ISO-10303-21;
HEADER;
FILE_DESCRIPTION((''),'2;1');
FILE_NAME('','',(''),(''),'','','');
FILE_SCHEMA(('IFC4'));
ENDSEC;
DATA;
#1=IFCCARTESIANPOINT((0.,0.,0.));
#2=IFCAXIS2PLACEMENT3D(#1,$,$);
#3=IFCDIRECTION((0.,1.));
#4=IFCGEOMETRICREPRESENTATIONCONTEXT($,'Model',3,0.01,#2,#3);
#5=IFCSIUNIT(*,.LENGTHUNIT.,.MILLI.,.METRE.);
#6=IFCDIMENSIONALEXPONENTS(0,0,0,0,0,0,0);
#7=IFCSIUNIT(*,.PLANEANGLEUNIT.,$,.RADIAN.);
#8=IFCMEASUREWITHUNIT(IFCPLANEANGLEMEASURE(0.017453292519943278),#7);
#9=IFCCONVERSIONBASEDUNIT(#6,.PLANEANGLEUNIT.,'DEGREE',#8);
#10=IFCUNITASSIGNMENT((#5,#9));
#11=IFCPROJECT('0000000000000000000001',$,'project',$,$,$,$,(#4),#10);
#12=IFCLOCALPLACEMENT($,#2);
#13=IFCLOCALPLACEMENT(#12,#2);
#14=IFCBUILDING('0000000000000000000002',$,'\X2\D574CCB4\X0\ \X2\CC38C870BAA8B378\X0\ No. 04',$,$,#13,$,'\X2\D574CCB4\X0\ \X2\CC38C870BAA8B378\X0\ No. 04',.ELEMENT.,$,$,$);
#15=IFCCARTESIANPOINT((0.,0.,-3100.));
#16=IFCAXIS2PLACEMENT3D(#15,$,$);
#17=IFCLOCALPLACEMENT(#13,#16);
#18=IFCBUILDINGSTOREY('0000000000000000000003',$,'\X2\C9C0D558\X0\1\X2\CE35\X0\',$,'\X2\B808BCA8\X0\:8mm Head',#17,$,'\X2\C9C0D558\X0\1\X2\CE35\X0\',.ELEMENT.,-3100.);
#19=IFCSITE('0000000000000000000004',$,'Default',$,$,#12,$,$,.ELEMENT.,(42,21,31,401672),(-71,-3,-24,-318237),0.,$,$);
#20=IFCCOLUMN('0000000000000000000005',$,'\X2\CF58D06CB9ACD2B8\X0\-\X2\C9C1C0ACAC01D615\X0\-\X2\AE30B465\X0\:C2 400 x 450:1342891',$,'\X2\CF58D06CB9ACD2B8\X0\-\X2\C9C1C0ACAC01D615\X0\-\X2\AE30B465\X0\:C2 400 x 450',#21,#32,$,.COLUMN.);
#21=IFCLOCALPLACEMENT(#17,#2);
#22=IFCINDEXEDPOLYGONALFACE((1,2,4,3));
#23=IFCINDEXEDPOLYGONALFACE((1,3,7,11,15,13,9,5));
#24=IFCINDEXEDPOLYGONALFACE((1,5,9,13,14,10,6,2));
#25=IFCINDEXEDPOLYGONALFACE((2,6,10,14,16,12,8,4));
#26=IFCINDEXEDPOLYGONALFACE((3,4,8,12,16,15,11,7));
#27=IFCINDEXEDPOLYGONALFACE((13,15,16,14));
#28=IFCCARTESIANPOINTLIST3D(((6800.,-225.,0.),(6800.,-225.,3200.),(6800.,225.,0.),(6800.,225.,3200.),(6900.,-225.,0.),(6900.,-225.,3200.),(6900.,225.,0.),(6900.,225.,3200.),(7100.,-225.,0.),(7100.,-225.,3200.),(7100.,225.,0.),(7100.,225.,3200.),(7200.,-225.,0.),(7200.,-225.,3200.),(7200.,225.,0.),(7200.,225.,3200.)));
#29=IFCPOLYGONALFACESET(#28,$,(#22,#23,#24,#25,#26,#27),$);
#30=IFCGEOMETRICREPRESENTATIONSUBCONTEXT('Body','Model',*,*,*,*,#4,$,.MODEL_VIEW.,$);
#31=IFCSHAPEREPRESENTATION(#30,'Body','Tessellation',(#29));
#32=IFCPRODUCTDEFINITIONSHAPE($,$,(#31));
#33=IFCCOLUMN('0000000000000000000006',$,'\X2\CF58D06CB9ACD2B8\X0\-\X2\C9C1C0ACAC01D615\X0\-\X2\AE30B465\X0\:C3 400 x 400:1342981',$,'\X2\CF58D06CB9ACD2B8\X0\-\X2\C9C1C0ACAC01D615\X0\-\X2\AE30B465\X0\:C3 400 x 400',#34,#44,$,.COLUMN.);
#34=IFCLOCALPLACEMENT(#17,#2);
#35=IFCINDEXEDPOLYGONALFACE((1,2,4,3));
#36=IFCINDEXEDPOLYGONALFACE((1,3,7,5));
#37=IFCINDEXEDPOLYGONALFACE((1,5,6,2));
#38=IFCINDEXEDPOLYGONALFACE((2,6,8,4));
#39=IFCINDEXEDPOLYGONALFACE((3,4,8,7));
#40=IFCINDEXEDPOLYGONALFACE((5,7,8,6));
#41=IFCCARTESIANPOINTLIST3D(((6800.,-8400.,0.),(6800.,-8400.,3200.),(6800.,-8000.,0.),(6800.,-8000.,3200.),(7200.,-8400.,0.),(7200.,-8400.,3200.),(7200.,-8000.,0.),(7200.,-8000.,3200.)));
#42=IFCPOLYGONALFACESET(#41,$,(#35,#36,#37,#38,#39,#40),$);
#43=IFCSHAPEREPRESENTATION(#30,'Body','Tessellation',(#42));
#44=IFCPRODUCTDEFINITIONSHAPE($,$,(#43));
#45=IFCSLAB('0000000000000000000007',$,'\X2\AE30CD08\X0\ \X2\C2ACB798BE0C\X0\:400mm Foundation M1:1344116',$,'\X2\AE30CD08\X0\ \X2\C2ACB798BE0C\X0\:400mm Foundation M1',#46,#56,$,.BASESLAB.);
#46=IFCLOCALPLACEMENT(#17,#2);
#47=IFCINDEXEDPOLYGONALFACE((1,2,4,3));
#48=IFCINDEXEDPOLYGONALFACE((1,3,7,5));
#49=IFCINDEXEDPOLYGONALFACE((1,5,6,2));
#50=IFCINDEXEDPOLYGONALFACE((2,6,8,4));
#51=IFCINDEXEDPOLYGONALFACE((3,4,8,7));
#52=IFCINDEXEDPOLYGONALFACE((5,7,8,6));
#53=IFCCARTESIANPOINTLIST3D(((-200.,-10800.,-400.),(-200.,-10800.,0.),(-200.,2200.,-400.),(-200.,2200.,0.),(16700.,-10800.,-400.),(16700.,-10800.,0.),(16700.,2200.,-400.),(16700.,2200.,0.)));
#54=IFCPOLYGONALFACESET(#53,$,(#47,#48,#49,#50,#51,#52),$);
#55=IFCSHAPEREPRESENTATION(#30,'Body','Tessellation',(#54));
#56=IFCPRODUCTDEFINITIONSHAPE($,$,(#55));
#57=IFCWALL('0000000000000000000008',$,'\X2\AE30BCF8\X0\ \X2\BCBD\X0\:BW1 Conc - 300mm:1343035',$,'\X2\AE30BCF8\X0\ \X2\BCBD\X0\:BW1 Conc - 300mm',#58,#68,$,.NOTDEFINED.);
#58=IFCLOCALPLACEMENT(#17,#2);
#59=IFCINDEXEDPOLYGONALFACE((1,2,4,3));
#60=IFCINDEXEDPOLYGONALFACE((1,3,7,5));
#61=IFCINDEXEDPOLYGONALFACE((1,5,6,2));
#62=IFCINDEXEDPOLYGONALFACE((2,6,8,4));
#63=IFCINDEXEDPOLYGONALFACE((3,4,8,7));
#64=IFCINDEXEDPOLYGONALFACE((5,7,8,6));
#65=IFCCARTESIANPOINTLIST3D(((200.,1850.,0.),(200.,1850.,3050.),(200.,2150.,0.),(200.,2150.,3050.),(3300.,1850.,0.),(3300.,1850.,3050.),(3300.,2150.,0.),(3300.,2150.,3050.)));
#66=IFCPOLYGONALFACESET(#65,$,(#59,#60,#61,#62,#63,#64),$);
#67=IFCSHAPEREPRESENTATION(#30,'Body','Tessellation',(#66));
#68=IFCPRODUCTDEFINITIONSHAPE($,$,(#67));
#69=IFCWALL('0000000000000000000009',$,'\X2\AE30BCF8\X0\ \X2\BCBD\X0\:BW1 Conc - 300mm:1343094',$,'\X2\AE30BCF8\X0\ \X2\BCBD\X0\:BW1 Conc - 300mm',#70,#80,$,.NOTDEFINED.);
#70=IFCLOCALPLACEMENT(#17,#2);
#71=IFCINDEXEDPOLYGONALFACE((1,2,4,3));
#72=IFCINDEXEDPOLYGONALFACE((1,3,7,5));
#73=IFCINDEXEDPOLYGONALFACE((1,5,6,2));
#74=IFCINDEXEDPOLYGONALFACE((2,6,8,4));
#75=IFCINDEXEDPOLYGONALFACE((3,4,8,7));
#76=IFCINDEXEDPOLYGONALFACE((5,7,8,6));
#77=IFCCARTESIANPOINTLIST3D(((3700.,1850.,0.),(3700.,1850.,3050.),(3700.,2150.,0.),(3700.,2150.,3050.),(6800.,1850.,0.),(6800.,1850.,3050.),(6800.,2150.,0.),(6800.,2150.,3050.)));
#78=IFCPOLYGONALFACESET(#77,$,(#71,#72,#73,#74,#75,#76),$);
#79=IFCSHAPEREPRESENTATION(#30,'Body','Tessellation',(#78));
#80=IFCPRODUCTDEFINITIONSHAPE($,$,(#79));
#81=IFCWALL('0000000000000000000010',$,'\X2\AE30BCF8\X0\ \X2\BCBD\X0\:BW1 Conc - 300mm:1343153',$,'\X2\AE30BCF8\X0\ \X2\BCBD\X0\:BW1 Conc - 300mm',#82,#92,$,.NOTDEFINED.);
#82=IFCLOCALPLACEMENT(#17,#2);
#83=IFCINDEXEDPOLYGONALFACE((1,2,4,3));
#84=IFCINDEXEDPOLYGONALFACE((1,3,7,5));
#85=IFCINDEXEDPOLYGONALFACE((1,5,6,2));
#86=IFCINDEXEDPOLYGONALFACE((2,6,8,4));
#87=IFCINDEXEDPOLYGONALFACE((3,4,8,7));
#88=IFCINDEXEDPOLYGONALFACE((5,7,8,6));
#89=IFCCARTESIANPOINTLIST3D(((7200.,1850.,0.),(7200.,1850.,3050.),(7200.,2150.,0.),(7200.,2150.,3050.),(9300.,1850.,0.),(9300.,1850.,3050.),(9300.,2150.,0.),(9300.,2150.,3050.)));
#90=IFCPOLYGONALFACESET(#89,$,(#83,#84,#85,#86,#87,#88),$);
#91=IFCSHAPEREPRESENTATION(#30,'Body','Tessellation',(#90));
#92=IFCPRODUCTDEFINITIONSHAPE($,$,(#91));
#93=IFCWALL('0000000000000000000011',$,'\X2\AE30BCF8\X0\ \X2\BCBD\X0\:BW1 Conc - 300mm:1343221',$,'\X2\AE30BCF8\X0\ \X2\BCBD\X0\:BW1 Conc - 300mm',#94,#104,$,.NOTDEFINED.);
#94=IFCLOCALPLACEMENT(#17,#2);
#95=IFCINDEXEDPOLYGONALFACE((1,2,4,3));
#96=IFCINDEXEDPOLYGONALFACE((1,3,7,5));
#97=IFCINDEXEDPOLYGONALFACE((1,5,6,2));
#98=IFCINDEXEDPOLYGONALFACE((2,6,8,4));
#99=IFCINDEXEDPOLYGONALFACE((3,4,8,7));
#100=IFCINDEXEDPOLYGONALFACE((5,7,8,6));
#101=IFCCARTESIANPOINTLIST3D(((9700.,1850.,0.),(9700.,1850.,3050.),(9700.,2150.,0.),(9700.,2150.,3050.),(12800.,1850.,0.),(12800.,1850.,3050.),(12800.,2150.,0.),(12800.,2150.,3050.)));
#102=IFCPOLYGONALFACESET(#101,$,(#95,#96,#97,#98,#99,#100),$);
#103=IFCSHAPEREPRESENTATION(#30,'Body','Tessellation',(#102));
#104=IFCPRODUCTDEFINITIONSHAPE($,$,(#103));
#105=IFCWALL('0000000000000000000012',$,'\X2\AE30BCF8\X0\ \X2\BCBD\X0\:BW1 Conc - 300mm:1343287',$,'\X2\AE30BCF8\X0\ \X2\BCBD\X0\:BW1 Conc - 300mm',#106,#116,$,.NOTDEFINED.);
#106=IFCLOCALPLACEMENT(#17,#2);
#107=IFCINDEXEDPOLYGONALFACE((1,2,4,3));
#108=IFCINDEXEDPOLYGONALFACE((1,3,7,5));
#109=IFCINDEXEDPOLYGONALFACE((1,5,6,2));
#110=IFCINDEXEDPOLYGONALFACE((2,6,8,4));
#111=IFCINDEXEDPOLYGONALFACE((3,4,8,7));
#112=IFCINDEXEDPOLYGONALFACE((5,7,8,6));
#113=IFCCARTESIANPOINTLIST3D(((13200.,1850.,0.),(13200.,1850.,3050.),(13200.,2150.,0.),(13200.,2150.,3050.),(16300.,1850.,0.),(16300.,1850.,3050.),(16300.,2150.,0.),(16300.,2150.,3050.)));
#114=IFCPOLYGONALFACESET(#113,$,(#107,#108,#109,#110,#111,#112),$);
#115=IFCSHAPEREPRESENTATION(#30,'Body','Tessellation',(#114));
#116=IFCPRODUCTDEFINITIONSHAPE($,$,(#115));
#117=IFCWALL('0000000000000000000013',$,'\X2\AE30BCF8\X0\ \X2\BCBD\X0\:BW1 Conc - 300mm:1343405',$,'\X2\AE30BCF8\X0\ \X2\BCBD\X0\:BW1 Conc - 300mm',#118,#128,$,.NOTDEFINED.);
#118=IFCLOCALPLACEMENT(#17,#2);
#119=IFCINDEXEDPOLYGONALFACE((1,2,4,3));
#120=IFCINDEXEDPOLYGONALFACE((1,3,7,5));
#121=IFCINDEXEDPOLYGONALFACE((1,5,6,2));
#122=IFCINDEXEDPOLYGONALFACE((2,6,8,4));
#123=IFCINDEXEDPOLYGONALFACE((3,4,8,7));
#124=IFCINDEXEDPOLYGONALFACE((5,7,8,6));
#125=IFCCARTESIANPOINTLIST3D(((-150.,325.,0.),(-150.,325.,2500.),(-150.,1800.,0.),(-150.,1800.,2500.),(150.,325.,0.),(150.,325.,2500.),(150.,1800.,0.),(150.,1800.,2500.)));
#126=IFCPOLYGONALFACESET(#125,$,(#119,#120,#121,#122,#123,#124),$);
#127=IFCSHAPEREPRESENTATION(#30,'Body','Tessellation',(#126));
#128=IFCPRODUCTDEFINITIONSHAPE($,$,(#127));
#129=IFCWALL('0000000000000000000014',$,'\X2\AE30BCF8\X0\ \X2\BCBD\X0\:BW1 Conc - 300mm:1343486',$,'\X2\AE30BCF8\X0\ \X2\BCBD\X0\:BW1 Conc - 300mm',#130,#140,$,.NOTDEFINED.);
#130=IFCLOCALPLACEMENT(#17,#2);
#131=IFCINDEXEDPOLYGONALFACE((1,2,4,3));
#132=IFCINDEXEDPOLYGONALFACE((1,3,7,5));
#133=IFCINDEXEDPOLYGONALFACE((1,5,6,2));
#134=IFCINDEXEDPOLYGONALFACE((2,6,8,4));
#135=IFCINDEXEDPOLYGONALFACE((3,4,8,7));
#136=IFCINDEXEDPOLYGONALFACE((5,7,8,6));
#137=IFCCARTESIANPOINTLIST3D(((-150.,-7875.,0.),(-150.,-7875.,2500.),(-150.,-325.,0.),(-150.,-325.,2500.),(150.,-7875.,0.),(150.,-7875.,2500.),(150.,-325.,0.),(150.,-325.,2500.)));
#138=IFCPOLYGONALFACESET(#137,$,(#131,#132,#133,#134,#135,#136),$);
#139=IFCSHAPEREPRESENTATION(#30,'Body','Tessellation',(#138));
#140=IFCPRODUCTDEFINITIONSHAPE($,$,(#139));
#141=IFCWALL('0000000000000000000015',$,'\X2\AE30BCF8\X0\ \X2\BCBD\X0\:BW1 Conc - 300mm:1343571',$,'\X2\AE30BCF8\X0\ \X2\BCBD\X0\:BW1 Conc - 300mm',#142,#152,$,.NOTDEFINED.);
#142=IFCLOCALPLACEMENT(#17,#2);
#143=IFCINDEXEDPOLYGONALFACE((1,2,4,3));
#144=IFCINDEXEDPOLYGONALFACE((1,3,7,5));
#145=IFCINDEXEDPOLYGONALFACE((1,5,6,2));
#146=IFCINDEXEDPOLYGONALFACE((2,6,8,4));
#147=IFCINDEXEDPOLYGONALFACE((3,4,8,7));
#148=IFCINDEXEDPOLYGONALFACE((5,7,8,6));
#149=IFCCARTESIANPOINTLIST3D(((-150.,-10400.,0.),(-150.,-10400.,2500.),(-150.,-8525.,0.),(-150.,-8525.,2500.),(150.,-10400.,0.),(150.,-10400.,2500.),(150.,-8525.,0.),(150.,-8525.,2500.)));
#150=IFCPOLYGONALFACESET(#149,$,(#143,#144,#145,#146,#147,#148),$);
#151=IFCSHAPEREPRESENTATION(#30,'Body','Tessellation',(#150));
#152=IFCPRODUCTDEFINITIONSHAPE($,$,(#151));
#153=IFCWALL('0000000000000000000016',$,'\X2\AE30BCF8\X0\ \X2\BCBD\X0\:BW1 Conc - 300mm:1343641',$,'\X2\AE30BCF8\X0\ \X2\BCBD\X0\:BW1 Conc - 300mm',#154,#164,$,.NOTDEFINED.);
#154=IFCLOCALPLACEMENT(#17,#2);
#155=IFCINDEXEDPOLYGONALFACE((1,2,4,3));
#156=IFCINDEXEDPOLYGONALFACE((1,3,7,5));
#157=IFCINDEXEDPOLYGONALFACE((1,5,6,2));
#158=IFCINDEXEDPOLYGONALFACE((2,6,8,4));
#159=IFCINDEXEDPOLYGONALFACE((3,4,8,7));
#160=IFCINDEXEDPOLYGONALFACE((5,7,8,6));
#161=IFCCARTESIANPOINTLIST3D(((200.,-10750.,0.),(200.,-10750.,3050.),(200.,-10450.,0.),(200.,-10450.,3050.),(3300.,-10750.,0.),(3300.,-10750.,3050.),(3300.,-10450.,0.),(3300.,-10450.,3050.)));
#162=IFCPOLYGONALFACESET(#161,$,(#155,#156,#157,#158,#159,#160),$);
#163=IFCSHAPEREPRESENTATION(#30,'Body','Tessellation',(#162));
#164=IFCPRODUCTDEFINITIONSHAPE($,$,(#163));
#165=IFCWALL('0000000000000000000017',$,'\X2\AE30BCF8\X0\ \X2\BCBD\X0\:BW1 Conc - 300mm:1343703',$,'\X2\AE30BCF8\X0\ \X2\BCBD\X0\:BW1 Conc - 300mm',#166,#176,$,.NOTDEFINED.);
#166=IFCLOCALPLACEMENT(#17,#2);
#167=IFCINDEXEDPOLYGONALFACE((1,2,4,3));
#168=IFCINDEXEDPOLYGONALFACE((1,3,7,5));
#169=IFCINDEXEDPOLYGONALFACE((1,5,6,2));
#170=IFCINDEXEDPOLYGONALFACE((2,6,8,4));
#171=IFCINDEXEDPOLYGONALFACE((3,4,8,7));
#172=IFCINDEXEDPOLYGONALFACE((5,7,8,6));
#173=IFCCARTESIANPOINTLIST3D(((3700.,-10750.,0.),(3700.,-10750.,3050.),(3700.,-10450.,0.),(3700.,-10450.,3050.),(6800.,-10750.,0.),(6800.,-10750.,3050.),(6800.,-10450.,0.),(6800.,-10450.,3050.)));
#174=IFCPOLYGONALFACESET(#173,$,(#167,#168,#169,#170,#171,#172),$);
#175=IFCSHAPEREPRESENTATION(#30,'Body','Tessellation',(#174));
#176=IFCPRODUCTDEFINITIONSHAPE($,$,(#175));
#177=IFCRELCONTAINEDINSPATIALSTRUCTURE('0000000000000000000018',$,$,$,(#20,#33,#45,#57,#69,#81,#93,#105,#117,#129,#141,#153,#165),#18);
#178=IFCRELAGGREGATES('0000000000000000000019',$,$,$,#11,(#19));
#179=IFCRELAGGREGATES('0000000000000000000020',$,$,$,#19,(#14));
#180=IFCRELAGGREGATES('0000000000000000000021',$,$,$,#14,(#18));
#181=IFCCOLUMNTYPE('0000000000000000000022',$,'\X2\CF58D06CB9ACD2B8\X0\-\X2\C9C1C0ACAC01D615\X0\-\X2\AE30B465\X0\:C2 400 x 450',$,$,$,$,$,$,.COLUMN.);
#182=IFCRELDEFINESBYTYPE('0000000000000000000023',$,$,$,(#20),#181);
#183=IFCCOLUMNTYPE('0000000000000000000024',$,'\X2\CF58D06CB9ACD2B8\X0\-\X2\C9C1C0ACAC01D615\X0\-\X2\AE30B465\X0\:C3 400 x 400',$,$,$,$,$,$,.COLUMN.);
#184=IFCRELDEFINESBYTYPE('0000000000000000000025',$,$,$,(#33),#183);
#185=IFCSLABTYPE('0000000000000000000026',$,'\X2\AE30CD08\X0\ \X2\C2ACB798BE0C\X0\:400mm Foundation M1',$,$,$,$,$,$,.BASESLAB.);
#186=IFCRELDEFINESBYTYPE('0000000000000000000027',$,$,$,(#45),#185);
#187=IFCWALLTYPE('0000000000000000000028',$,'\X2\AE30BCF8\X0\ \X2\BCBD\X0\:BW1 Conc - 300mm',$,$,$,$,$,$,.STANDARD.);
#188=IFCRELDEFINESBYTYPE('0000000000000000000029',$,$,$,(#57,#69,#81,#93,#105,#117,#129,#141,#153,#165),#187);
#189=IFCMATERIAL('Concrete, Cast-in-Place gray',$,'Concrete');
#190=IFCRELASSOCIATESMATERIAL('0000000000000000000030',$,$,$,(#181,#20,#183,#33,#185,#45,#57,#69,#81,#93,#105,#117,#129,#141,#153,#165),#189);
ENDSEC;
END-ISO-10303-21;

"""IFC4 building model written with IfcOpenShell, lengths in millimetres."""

from ifc_helpers import new_model, entity, si_unit, converted_unit, direction, frame, origin, place, context, subcontext, project, spatial, indexed_curve, outline, extrude, source, transform, mapped, material, type_object, type_shapes, element, save


model = new_model("IFC4")

# Units and contexts
model_context = context("Model", 3, precision=0.01, world=origin(), true_north=direction((0.0, 1.0)))
body_context = subcontext(model_context, "Body", "Model", "MODEL_VIEW")
ifc_project = project(units=[si_unit("LENGTHUNIT", "METRE", prefix="MILLI"), converted_unit("PLANEANGLEUNIT", "DEGREE", entity("IfcPlaneAngleMeasure", 0.017453292519943278), si_unit("PLANEANGLEUNIT", "RADIAN"), dimensions=[0, 0, 0, 0, 0, 0, 0])], contexts=[model_context])

# Site, building, storey
site_placement = place(None, origin())
site = spatial("IfcSite", under=ifc_project, at=site_placement, Name="Default", CompositionType="ELEMENT", RefLatitude=(42, 21, 31, 401672), RefLongitude=(-71, -3, -24, -318237), RefElevation=0.0)
building_placement = place(site_placement, origin())
building = spatial("IfcBuilding", under=site, at=building_placement, Name="해체 참조모델 No. 04", LongName="해체 참조모델 No. 04", CompositionType="ELEMENT")
storey_placement = place(building_placement, frame((0.0, 0.0, -3100.0)))
storey = spatial("IfcBuildingStorey", under=building, at=storey_placement, Name="지하1층", ObjectType="레벨:8mm Head", LongName="지하1층", CompositionType="ELEMENT", Elevation=-3100.0)

# Columns
ifc_material_1 = material(Name="Concrete, Cast-in-Place gray", Category="Concrete")
column_type_1 = type_object("IfcColumnType", Name="콘크리트-직사각형-기둥:C2 400 x 450", PredefinedType="COLUMN", material=ifc_material_1)
shared_shape_1 = source(origin(), body_context, "Body", "SweptSolid", [
    extrude(outline(indexed_curve([(-200.0, -225.0), (-100.0, -225.0), (100.0, -225.0), (200.0, -225.0), (200.0, 225.0), (100.0, 225.0), (-100.0, 225.0), (-200.0, 225.0), (-200.0, -225.0)], self_intersect=False)), frame((7000.0, 0.0, -3100.0), z_axis=(0.0, 0.0, 1.0), x_axis=(-1.0, 0.0, 0.0)), (0.0, 0.0, 1.0), 3200.0),
])
type_shapes(column_type_1, [shared_shape_1])
column_1_placement = place(storey_placement, frame((0.0, 0.0, 3100.0)))
element("IfcColumn", 1, at=column_1_placement, inside=storey, type_object=column_type_1, material=ifc_material_1, Name="콘크리트-직사각형-기둥:C2 400 x 450:1342891", ObjectType="콘크리트-직사각형-기둥:C2 400 x 450", PredefinedType="COLUMN", context=body_context, shape_type="MappedRepresentation", body=[
    mapped(shared_shape_1, transform((0.0, 0.0, 0.0), scale=1.0)),
])
column_type_2 = type_object("IfcColumnType", Name="콘크리트-직사각형-기둥:C3 400 x 400", PredefinedType="COLUMN", material=ifc_material_1)
shared_shape_2 = source(origin(), body_context, "Body", "SweptSolid", [
    extrude(outline(indexed_curve([(-200.0, -200.0), (200.0, -200.0), (200.0, 200.0), (-200.0, 200.0), (-200.0, -200.0)], self_intersect=False)), frame((7000.0, -8200.0, -3100.0), z_axis=(0.0, 0.0, 1.0), x_axis=(-1.0, 0.0, 0.0)), (0.0, 0.0, 1.0), 3200.0),
])
type_shapes(column_type_2, [shared_shape_2])
column_2_placement = place(storey_placement, frame((0.0, 0.0, 3100.0)))
element("IfcColumn", 2, at=column_2_placement, inside=storey, type_object=column_type_2, material=ifc_material_1, Name="콘크리트-직사각형-기둥:C3 400 x 400:1342981", ObjectType="콘크리트-직사각형-기둥:C3 400 x 400", PredefinedType="COLUMN", context=body_context, shape_type="MappedRepresentation", body=[
    mapped(shared_shape_2, transform((0.0, 0.0, 0.0), scale=1.0)),
])

# Slab
slab_type = type_object("IfcSlabType", Name="기초 슬래브:400mm Foundation M1", PredefinedType="BASESLAB", material=ifc_material_1)
slab_placement = place(storey_placement, origin())
element("IfcSlab", 3, at=slab_placement, inside=storey, type_object=slab_type, material=ifc_material_1, Name="기초 슬래브:400mm Foundation M1:1344116", ObjectType="기초 슬래브:400mm Foundation M1", PredefinedType="BASESLAB", context=body_context, shape_type="SweptSolid", body=[
    extrude(outline(indexed_curve([(-6500.0, -8450.0), (6500.0, -8450.0), (6500.0, 8450.0), (-6500.0, 8450.0), (-6500.0, -8450.0)], self_intersect=False)), frame((8250.0, -4300.0, 0.0), z_axis=(0.0, 0.0, -1.0), x_axis=(0.0, 1.0, 0.0)), (0.0, 0.0, 1.0), 400.0),
])

# Walls
wall_type_1 = type_object("IfcWallType", Name="기본 벽:BW1 Conc - 300mm", PredefinedType="STANDARD")
wall_1_placement = place(storey_placement, frame((200.0, 2000.0, 0.0)))
element("IfcWall", 4, at=wall_1_placement, inside=storey, type_object=wall_type_1, material=ifc_material_1, Name="기본 벽:BW1 Conc - 300mm:1343035", ObjectType="기본 벽:BW1 Conc - 300mm", PredefinedType="NOTDEFINED", context=body_context, shape_type="SweptSolid", body=[
    extrude(outline(indexed_curve([(3100.0, 150.0), (0.0, 150.0), (0.0, -150.0), (3100.0, -150.0), (3100.0, 150.0)], self_intersect=False)), origin(), (0.0, 0.0, 1.0), 3050.0),
])
wall_2_placement = place(storey_placement, frame((3700.0, 2000.0, 0.0)))
element("IfcWall", 5, at=wall_2_placement, inside=storey, type_object=wall_type_1, material=ifc_material_1, Name="기본 벽:BW1 Conc - 300mm:1343094", ObjectType="기본 벽:BW1 Conc - 300mm", PredefinedType="NOTDEFINED", context=body_context, shape_type="SweptSolid", body=[
    extrude(outline(indexed_curve([(3100.0, 150.0), (0.0, 150.0), (0.0, -150.0), (3100.0, -150.0), (3100.0, 150.0)], self_intersect=False)), origin(), (0.0, 0.0, 1.0), 3050.0),
])
wall_3_placement = place(storey_placement, frame((7200.0, 2000.0, 0.0)))
element("IfcWall", 6, at=wall_3_placement, inside=storey, type_object=wall_type_1, material=ifc_material_1, Name="기본 벽:BW1 Conc - 300mm:1343153", ObjectType="기본 벽:BW1 Conc - 300mm", PredefinedType="NOTDEFINED", context=body_context, shape_type="SweptSolid", body=[
    extrude(outline(indexed_curve([(2100.0, 150.0), (0.0, 150.0), (0.0, -150.0), (2100.0, -150.0), (2100.0, 150.0)], self_intersect=False)), origin(), (0.0, 0.0, 1.0), 3050.0),
])
wall_4_placement = place(storey_placement, frame((9700.0, 2000.0, 0.0)))
element("IfcWall", 7, at=wall_4_placement, inside=storey, type_object=wall_type_1, material=ifc_material_1, Name="기본 벽:BW1 Conc - 300mm:1343221", ObjectType="기본 벽:BW1 Conc - 300mm", PredefinedType="NOTDEFINED", context=body_context, shape_type="SweptSolid", body=[
    extrude(outline(indexed_curve([(3100.0, 150.0), (0.0, 150.0), (0.0, -150.0), (3100.0, -150.0), (3100.0, 150.0)], self_intersect=False)), origin(), (0.0, 0.0, 1.0), 3050.0),
])
wall_5_placement = place(storey_placement, frame((13200.0, 2000.0, 0.0)))
element("IfcWall", 8, at=wall_5_placement, inside=storey, type_object=wall_type_1, material=ifc_material_1, Name="기본 벽:BW1 Conc - 300mm:1343287", ObjectType="기본 벽:BW1 Conc - 300mm", PredefinedType="NOTDEFINED", context=body_context, shape_type="SweptSolid", body=[
    extrude(outline(indexed_curve([(3100.0, 150.0), (0.0, 150.0), (0.0, -150.0), (3100.0, -150.0), (3100.0, 150.0)], self_intersect=False)), origin(), (0.0, 0.0, 1.0), 3050.0),
])
wall_6_placement = place(storey_placement, frame((0.0, 1800.0, 0.0), z_axis=(0.0, 0.0, 1.0), x_axis=(0.0, -1.0, 0.0)))
element("IfcWall", 9, at=wall_6_placement, inside=storey, type_object=wall_type_1, material=ifc_material_1, Name="기본 벽:BW1 Conc - 300mm:1343405", ObjectType="기본 벽:BW1 Conc - 300mm", PredefinedType="NOTDEFINED", context=body_context, shape_type="SweptSolid", body=[
    extrude(outline(indexed_curve([(1475.0, 150.0), (0.0, 150.0), (0.0, -150.0), (1475.0, -150.0), (1475.0, 150.0)], self_intersect=False)), origin(), (0.0, 0.0, 1.0), 2500.0),
])
wall_7_placement = place(storey_placement, frame((0.0, -325.0, 0.0), z_axis=(0.0, 0.0, 1.0), x_axis=(0.0, -1.0, 0.0)))
element("IfcWall", 10, at=wall_7_placement, inside=storey, type_object=wall_type_1, material=ifc_material_1, Name="기본 벽:BW1 Conc - 300mm:1343486", ObjectType="기본 벽:BW1 Conc - 300mm", PredefinedType="NOTDEFINED", context=body_context, shape_type="SweptSolid", body=[
    extrude(outline(indexed_curve([(7550.0, 150.0), (0.0, 150.0), (0.0, -150.0), (7550.0, -150.0), (7550.0, 150.0)], self_intersect=False)), origin(), (0.0, 0.0, 1.0), 2500.0),
])
wall_8_placement = place(storey_placement, frame((0.0, -8525.0, 0.0), z_axis=(0.0, 0.0, 1.0), x_axis=(0.0, -1.0, 0.0)))
element("IfcWall", 11, at=wall_8_placement, inside=storey, type_object=wall_type_1, material=ifc_material_1, Name="기본 벽:BW1 Conc - 300mm:1343571", ObjectType="기본 벽:BW1 Conc - 300mm", PredefinedType="NOTDEFINED", context=body_context, shape_type="SweptSolid", body=[
    extrude(outline(indexed_curve([(1875.0, 150.0), (0.0, 150.0), (0.0, -150.0), (1875.0, -150.0), (1875.0, 150.0)], self_intersect=False)), origin(), (0.0, 0.0, 1.0), 2500.0),
])
wall_9_placement = place(storey_placement, frame((200.0, -10600.0, 0.0)))
element("IfcWall", 12, at=wall_9_placement, inside=storey, type_object=wall_type_1, material=ifc_material_1, Name="기본 벽:BW1 Conc - 300mm:1343641", ObjectType="기본 벽:BW1 Conc - 300mm", PredefinedType="NOTDEFINED", context=body_context, shape_type="SweptSolid", body=[
    extrude(outline(indexed_curve([(3100.0, 150.0), (0.0, 150.0), (0.0, -150.0), (3100.0, -150.0), (3100.0, 150.0)], self_intersect=False)), origin(), (0.0, 0.0, 1.0), 3050.0),
])
wall_10_placement = place(storey_placement, frame((3700.0, -10600.0, 0.0)))
element("IfcWall", 13, at=wall_10_placement, inside=storey, type_object=wall_type_1, material=ifc_material_1, Name="기본 벽:BW1 Conc - 300mm:1343703", ObjectType="기본 벽:BW1 Conc - 300mm", PredefinedType="NOTDEFINED", context=body_context, shape_type="SweptSolid", body=[
    extrude(outline(indexed_curve([(3100.0, 150.0), (0.0, 150.0), (0.0, -150.0), (3100.0, -150.0), (3100.0, 150.0)], self_intersect=False)), origin(), (0.0, 0.0, 1.0), 3050.0),
])

save(model, "model.ifc")
